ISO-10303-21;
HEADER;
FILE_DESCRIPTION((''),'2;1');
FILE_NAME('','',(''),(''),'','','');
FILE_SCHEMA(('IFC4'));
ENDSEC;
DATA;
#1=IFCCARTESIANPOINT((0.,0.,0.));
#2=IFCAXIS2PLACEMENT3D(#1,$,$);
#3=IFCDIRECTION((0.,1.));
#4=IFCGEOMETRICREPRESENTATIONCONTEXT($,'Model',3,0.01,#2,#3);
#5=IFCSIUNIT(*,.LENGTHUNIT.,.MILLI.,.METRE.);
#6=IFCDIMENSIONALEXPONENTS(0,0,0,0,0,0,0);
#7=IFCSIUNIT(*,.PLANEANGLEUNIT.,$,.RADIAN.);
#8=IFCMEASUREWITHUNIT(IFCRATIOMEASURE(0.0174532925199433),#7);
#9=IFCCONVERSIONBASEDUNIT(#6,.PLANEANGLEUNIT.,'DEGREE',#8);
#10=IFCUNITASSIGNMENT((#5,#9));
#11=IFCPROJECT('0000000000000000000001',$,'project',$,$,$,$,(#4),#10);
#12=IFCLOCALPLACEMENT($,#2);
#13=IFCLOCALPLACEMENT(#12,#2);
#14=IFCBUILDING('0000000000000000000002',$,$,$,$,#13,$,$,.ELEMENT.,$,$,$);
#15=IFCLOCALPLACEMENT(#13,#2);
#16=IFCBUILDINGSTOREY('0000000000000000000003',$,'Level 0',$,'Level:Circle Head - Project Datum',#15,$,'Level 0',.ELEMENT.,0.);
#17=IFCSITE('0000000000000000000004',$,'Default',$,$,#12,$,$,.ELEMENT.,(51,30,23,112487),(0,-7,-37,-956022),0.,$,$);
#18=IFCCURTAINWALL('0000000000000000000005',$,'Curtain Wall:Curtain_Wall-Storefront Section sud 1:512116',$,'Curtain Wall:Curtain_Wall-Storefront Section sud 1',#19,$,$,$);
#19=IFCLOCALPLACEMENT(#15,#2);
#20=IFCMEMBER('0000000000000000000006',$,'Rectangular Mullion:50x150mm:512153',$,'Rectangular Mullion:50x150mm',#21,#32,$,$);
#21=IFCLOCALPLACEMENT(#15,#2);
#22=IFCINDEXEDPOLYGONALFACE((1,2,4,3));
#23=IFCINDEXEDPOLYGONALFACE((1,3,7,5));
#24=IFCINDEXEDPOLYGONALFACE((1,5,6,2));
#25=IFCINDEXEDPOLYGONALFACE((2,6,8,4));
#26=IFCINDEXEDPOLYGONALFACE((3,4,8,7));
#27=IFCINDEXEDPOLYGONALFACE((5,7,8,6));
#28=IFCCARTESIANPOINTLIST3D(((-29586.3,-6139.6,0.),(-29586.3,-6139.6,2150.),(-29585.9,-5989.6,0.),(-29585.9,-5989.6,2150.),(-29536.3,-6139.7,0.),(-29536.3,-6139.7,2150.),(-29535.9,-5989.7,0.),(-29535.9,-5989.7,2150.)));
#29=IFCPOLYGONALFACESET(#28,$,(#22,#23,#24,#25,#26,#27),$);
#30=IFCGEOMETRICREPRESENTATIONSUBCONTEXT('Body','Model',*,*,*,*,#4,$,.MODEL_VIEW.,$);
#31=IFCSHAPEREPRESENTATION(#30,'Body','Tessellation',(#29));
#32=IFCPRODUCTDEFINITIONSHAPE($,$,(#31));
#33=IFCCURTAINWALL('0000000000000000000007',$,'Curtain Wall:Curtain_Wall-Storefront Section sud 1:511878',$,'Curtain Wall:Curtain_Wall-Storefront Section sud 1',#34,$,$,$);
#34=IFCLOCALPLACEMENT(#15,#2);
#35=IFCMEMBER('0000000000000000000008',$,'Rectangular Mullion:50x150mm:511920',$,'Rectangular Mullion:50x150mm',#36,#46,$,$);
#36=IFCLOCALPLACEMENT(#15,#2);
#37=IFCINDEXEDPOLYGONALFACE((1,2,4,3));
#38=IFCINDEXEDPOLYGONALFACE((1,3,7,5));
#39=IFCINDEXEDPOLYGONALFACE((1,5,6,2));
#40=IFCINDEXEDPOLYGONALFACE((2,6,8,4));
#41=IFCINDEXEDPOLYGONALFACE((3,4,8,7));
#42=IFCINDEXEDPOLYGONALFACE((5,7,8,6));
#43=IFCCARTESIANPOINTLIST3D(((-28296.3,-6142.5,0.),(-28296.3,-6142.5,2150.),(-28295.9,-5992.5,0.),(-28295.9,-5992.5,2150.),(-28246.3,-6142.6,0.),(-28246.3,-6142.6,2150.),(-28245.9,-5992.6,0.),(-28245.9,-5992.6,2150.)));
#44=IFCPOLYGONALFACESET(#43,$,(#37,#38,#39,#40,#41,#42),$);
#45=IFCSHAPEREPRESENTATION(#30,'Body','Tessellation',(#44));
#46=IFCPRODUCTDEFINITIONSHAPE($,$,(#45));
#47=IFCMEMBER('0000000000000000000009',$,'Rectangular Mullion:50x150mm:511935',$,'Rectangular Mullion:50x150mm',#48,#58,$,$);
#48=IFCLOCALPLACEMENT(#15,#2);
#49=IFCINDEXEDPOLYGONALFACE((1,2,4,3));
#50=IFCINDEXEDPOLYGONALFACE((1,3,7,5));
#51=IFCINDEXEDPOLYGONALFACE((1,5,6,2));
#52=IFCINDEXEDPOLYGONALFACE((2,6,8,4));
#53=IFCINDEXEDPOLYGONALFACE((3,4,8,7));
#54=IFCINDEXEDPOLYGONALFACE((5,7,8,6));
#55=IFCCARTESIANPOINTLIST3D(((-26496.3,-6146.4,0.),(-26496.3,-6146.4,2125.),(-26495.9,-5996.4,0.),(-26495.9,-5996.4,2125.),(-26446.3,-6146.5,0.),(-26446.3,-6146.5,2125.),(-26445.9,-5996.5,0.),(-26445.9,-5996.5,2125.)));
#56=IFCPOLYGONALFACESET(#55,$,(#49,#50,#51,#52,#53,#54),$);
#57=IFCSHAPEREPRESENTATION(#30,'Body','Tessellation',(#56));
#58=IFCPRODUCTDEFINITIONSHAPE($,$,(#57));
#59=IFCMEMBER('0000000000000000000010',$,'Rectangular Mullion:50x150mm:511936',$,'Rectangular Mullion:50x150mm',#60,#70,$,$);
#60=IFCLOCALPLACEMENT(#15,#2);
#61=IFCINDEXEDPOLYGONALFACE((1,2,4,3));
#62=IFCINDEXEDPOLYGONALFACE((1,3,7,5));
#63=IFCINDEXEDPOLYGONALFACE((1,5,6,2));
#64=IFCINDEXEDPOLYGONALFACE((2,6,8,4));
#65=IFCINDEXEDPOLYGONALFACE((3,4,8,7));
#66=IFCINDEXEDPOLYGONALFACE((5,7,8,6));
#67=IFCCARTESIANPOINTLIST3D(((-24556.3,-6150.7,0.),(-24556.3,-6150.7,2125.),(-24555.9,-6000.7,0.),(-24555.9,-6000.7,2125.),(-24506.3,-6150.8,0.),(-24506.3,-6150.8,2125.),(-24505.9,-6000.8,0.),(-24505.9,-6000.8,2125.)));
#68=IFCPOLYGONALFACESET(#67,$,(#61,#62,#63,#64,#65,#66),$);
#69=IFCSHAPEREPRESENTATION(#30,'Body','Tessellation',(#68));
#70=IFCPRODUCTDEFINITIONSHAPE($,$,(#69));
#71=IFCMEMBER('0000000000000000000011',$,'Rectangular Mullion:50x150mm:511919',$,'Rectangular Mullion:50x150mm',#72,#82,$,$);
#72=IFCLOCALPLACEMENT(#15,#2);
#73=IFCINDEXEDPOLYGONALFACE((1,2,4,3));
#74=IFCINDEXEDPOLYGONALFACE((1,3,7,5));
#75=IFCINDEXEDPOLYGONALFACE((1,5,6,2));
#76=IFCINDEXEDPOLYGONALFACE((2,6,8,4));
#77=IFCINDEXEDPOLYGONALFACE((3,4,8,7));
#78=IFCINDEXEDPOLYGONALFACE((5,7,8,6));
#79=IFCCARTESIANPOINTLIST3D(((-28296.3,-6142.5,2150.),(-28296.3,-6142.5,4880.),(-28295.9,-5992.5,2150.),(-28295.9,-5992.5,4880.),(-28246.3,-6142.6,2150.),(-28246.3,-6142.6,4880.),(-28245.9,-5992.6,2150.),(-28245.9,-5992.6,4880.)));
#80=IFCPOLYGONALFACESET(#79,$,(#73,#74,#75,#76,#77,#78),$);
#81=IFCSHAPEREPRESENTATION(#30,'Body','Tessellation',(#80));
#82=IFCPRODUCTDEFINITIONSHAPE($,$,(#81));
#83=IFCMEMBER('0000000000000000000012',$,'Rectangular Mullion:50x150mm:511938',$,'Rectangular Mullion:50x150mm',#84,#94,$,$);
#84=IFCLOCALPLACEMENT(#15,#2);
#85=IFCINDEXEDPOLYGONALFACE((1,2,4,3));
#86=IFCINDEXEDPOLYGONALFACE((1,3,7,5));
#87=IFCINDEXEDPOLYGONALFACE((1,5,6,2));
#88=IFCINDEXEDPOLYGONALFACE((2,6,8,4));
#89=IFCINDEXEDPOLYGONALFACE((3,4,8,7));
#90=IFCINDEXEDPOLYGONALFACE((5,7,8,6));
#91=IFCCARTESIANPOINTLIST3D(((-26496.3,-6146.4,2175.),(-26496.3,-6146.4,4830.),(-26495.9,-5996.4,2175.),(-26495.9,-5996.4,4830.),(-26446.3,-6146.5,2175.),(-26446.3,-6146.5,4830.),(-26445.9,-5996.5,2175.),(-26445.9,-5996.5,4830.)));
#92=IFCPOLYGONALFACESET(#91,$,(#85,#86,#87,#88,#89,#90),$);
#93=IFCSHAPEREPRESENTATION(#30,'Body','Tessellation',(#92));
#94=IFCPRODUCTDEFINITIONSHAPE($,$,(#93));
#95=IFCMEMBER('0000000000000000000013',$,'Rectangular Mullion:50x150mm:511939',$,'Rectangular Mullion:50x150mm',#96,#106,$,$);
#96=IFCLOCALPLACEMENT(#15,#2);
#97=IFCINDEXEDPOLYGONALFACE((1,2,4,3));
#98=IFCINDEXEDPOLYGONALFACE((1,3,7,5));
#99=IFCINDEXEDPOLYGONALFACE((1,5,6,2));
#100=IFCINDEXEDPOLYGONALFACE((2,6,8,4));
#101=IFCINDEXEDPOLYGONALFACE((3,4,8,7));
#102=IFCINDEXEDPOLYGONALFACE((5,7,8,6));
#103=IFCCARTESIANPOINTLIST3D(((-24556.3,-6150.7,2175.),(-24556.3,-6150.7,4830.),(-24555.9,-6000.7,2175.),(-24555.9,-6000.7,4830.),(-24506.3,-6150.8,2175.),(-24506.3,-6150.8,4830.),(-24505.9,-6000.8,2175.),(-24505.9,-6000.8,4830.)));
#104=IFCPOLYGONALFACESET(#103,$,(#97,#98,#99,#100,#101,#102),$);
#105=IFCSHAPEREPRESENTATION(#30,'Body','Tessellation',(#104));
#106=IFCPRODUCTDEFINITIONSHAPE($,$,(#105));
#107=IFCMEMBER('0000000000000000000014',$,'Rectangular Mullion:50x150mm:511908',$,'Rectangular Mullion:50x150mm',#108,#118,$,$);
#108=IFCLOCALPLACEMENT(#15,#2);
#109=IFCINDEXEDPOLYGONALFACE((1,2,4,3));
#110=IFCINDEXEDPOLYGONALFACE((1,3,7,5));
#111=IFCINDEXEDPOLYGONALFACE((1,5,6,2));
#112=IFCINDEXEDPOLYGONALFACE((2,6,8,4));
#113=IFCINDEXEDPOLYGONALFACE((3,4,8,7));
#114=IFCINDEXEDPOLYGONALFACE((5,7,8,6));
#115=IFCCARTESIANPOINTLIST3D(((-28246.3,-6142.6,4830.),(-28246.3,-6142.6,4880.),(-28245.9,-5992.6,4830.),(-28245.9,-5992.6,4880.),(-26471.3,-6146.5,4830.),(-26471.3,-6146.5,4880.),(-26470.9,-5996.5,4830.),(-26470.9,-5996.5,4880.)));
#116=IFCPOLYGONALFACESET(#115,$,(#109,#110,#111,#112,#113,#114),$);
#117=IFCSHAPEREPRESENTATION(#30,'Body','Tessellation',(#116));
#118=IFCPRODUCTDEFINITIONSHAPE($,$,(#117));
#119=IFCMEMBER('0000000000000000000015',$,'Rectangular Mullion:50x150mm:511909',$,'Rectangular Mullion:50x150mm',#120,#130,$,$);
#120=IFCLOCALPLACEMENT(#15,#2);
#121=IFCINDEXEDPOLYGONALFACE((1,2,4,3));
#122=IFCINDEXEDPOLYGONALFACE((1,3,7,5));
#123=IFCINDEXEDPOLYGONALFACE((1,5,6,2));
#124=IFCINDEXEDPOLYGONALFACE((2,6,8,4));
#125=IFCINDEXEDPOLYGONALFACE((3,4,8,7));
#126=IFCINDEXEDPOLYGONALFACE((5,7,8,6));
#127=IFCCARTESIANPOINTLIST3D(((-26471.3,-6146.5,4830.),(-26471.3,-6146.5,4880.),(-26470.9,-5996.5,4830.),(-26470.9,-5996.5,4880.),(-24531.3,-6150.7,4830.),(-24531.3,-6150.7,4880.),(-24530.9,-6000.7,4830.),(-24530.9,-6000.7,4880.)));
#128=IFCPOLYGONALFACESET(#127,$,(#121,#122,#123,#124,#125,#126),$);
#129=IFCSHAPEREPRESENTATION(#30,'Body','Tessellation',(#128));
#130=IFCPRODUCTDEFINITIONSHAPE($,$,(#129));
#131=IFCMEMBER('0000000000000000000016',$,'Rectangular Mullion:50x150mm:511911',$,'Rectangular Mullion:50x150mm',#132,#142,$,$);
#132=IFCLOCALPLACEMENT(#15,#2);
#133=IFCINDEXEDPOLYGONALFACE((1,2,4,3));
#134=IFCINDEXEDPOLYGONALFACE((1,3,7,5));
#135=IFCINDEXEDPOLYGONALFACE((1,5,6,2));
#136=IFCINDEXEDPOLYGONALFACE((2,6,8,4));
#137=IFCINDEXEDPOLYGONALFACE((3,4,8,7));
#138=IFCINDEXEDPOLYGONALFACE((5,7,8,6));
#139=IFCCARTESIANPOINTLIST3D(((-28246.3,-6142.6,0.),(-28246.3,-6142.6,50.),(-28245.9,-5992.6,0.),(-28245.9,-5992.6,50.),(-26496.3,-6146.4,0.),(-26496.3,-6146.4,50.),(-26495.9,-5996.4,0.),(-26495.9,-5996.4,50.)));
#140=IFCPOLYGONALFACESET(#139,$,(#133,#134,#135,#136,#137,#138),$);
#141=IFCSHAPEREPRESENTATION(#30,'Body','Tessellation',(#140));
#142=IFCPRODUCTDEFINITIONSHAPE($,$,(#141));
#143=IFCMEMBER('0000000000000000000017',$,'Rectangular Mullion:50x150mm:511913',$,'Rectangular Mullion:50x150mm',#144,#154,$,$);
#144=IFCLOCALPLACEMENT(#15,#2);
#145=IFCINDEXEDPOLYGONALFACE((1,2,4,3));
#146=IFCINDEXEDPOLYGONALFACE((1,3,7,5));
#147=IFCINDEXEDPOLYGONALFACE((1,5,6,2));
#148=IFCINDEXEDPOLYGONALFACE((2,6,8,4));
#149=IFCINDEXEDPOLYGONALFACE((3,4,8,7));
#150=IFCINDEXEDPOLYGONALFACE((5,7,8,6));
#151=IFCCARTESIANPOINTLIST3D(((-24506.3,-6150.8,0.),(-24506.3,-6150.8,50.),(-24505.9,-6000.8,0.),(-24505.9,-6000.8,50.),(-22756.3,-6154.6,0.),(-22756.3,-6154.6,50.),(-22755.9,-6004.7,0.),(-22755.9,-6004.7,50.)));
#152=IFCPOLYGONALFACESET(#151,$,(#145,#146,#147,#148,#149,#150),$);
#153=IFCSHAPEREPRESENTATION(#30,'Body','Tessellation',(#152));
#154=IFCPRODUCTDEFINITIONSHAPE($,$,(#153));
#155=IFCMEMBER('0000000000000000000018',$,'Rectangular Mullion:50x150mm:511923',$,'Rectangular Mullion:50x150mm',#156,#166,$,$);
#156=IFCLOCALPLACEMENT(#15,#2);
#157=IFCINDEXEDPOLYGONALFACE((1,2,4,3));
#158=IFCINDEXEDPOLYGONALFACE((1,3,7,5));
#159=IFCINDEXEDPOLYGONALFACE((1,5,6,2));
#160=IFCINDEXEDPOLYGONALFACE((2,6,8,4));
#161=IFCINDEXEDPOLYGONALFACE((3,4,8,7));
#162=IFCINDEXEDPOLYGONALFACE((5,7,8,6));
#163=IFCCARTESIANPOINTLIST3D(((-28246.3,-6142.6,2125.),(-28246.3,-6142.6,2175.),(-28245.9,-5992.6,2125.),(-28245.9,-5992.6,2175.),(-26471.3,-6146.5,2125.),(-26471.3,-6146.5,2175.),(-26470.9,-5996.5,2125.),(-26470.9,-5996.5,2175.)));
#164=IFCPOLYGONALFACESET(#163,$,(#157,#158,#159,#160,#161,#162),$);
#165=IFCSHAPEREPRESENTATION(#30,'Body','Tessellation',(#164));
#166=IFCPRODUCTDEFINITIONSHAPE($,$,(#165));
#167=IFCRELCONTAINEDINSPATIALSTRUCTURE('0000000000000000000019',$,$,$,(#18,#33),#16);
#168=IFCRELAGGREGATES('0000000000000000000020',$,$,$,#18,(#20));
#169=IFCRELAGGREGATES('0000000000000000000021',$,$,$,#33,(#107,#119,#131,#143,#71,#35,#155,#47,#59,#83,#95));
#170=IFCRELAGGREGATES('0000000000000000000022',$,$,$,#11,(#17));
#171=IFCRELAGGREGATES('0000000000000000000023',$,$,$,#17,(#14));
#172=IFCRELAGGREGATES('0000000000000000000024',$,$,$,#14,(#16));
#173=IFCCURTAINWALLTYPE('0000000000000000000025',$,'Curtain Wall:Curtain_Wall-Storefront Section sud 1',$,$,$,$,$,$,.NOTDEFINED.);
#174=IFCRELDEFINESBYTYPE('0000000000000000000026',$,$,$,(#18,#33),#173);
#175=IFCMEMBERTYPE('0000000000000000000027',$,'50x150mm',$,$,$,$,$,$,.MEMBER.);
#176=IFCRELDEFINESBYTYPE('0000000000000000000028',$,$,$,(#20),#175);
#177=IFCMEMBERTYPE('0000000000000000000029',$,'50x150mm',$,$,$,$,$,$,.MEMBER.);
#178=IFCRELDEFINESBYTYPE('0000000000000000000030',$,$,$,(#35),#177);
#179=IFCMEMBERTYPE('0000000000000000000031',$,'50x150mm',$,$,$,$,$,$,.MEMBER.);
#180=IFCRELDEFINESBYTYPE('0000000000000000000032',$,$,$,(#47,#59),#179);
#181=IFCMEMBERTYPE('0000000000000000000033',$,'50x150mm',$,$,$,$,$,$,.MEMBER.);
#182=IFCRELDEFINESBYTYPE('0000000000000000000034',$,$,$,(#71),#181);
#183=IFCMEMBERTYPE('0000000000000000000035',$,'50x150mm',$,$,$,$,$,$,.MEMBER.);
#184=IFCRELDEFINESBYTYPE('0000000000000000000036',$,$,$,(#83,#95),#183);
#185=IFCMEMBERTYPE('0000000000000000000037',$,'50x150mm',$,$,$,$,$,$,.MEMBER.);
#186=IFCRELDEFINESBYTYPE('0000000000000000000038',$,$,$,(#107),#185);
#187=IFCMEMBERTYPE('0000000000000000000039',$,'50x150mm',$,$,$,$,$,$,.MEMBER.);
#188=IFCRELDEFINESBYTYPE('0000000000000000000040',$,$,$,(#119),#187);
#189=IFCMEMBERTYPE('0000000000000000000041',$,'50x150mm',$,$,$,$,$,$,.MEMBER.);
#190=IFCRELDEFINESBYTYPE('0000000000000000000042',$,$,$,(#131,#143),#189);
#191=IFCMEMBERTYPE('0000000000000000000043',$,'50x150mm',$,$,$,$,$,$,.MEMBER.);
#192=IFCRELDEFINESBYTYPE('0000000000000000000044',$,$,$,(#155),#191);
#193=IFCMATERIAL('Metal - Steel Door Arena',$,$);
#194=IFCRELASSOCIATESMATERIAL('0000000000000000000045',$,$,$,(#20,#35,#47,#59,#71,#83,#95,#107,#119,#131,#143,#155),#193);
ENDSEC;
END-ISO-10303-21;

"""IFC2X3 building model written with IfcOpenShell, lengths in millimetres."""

from ifc_helpers import new_model, entity, si_unit, converted_unit, direction, frame, origin, origin_2d_with_axis, place, context, subcontext, project, spatial, rectangle, extrude, source, transform, mapped, material, type_object, type_shapes, element, aggregate, save


model = new_model("IFC2X3")

# Units and contexts
model_context = context("Model", 3, precision=0.01, world=origin(), true_north=direction((0.0, 1.0)))
body_context = subcontext(model_context, "Body", "Model", "MODEL_VIEW")
ifc_project = project(units=[si_unit("LENGTHUNIT", "METRE", prefix="MILLI"), converted_unit("PLANEANGLEUNIT", "DEGREE", entity("IfcRatioMeasure", 0.0174532925199433), si_unit("PLANEANGLEUNIT", "RADIAN"), dimensions=[0, 0, 0, 0, 0, 0, 0])], contexts=[model_context])

# Site, building, storey
site_placement = place(None, origin())
site = spatial("IfcSite", under=ifc_project, at=site_placement, Name="Default", CompositionType="ELEMENT", RefLatitude=(51, 30, 23, 112487), RefLongitude=(0, -7, -37, -956022), RefElevation=0.0)
building_placement = place(site_placement, origin())
building = spatial("IfcBuilding", under=site, at=building_placement, CompositionType="ELEMENT")
storey_placement = place(building_placement, origin())
storey = spatial("IfcBuildingStorey", under=building, at=storey_placement, Name="Level 0", ObjectType="Level:Circle Head - Project Datum", LongName="Level 0", CompositionType="ELEMENT", Elevation=0.0)

# Curtain wall, member
curtain_wall_type = type_object("IfcCurtainWallType", Name="Curtain Wall:Curtain_Wall-Storefront Section sud 1", PredefinedType="NOTDEFINED")
curtain_wall_1_placement = place(storey_placement, origin())
curtain_wall_1 = element("IfcCurtainWall", 1, at=curtain_wall_1_placement, inside=storey, type_object=curtain_wall_type, Name="Curtain Wall:Curtain_Wall-Storefront Section sud 1:512116", ObjectType="Curtain Wall:Curtain_Wall-Storefront Section sud 1")
ifc_material_1 = material(Name="Metal - Steel Door Arena")
member_type_1 = type_object("IfcMemberType", Name="50x150mm", PredefinedType="MEMBER")
shared_shape_1 = source(origin(), body_context, "Body", "SweptSolid", [
    extrude(rectangle(XDim=150.0, YDim=50.0, at=origin_2d_with_axis()), frame((-25.0, 0.0, -2150.0), z_axis=(0.0, 0.0, 1.0), x_axis=(0.0, -1.0, 0.0)), (0.0, 0.0, 1.0), 2150.0),
])
type_shapes(member_type_1, [shared_shape_1])
member_1_placement = place(storey_placement, frame((-29536.1, -6064.7, 0.0), z_axis=(0.0, 0.0, -1.0), x_axis=(0.999998, -0.002199, 0.0)))
member_1 = element("IfcMember", 2, at=member_1_placement, type_object=member_type_1, material=ifc_material_1, Name="Rectangular Mullion:50x150mm:512153", ObjectType="Rectangular Mullion:50x150mm", context=body_context, shape_type="MappedRepresentation", body=[
    mapped(shared_shape_1, transform((0.0, 0.0, 0.0), scale=1.0)),
])
aggregate(curtain_wall_1, [member_1])

# Curtain wall, members
curtain_wall_2_placement = place(storey_placement, origin())
curtain_wall_2 = element("IfcCurtainWall", 3, at=curtain_wall_2_placement, inside=storey, type_object=curtain_wall_type, Name="Curtain Wall:Curtain_Wall-Storefront Section sud 1:511878", ObjectType="Curtain Wall:Curtain_Wall-Storefront Section sud 1")
member_type_2 = type_object("IfcMemberType", Name="50x150mm", PredefinedType="MEMBER")
shared_shape_2 = source(origin(), body_context, "Body", "SweptSolid", [
    extrude(rectangle(XDim=150.0, YDim=50.0, at=origin_2d_with_axis()), frame((-25.0, 0.0, -2150.0), z_axis=(0.0, 0.0, 1.0), x_axis=(0.0, -1.0, 0.0)), (0.0, 0.0, 1.0), 2150.0),
])
type_shapes(member_type_2, [shared_shape_2])
member_2_placement = place(storey_placement, frame((-28296.1, -6067.5, 2150.0), z_axis=(0.0, 0.0, 1.0), x_axis=(-0.999998, 0.002199, 0.0)))
member_2 = element("IfcMember", 4, at=member_2_placement, type_object=member_type_2, material=ifc_material_1, Name="Rectangular Mullion:50x150mm:511920", ObjectType="Rectangular Mullion:50x150mm", context=body_context, shape_type="MappedRepresentation", body=[
    mapped(shared_shape_2, transform((0.0, 0.0, 0.0), scale=1.0)),
])
member_type_3 = type_object("IfcMemberType", Name="50x150mm", PredefinedType="MEMBER")
shared_shape_3 = source(origin(), body_context, "Body", "SweptSolid", [
    extrude(rectangle(XDim=150.0, YDim=50.0, at=origin_2d_with_axis()), frame((0.0, 0.0, -2125.0), z_axis=(0.0, 0.0, 1.0), x_axis=(0.0, -1.0, 0.0)), (0.0, 0.0, 1.0), 2125.0),
])
type_shapes(member_type_3, [shared_shape_3])
member_3_placement = place(storey_placement, frame((-26471.1, -6071.5, 0.0), z_axis=(0.0, 0.0, -1.0), x_axis=(0.999998, -0.002199, 0.0)))
member_3 = element("IfcMember", 5, at=member_3_placement, type_object=member_type_3, material=ifc_material_1, Name="Rectangular Mullion:50x150mm:511935", ObjectType="Rectangular Mullion:50x150mm", context=body_context, shape_type="MappedRepresentation", body=[
    mapped(shared_shape_3, transform((0.0, 0.0, 0.0), scale=1.0)),
])
member_4_placement = place(storey_placement, frame((-24531.1, -6075.7, 0.0), z_axis=(0.0, 0.0, -1.0), x_axis=(0.999998, -0.002199, 0.0)))
member_4 = element("IfcMember", 6, at=member_4_placement, type_object=member_type_3, material=ifc_material_1, Name="Rectangular Mullion:50x150mm:511936", ObjectType="Rectangular Mullion:50x150mm", context=body_context, shape_type="MappedRepresentation", body=[
    mapped(shared_shape_3, transform((0.0, 0.0, 0.0), scale=1.0)),
])
member_type_4 = type_object("IfcMemberType", Name="50x150mm", PredefinedType="MEMBER")
shared_shape_4 = source(origin(), body_context, "Body", "SweptSolid", [
    extrude(rectangle(XDim=150.0, YDim=50.0, at=origin_2d_with_axis()), frame((-25.0, 0.0, -2730.0), z_axis=(0.0, 0.0, 1.0), x_axis=(0.0, -1.0, 0.0)), (0.0, 0.0, 1.0), 2730.0),
])
type_shapes(member_type_4, [shared_shape_4])
member_5_placement = place(storey_placement, frame((-28296.1, -6067.5, 4880.0), z_axis=(0.0, 0.0, 1.0), x_axis=(-0.999998, 0.002199, 0.0)))
member_5 = element("IfcMember", 7, at=member_5_placement, type_object=member_type_4, material=ifc_material_1, Name="Rectangular Mullion:50x150mm:511919", ObjectType="Rectangular Mullion:50x150mm", context=body_context, shape_type="MappedRepresentation", body=[
    mapped(shared_shape_4, transform((0.0, 0.0, 0.0), scale=1.0)),
])
member_type_5 = type_object("IfcMemberType", Name="50x150mm", PredefinedType="MEMBER")
shared_shape_5 = source(origin(), body_context, "Body", "SweptSolid", [
    extrude(rectangle(XDim=150.0, YDim=50.0, at=origin_2d_with_axis()), frame((0.0, 0.0, -2655.0), z_axis=(0.0, 0.0, 1.0), x_axis=(0.0, -1.0, 0.0)), (0.0, 0.0, 1.0), 2655.0),
])
type_shapes(member_type_5, [shared_shape_5])
member_6_placement = place(storey_placement, frame((-26471.1, -6071.5, 2175.0), z_axis=(0.0, 0.0, -1.0), x_axis=(0.999998, -0.002199, 0.0)))
member_6 = element("IfcMember", 8, at=member_6_placement, type_object=member_type_5, material=ifc_material_1, Name="Rectangular Mullion:50x150mm:511938", ObjectType="Rectangular Mullion:50x150mm", context=body_context, shape_type="MappedRepresentation", body=[
    mapped(shared_shape_5, transform((0.0, 0.0, 0.0), scale=1.0)),
])
member_7_placement = place(storey_placement, frame((-24531.1, -6075.7, 2175.0), z_axis=(0.0, 0.0, -1.0), x_axis=(0.999998, -0.002199, 0.0)))
member_7 = element("IfcMember", 9, at=member_7_placement, type_object=member_type_5, material=ifc_material_1, Name="Rectangular Mullion:50x150mm:511939", ObjectType="Rectangular Mullion:50x150mm", context=body_context, shape_type="MappedRepresentation", body=[
    mapped(shared_shape_5, transform((0.0, 0.0, 0.0), scale=1.0)),
])
member_type_6 = type_object("IfcMemberType", Name="50x150mm", PredefinedType="MEMBER")
shared_shape_6 = source(origin(), body_context, "Body", "SweptSolid", [
    extrude(rectangle(XDim=150.0, YDim=50.0, at=origin_2d_with_axis()), frame((-25.0, 0.0, -1775.0), z_axis=(0.0, 0.0, 1.0), x_axis=(0.0, -1.0, 0.0)), (0.0, 0.0, 1.0), 1775.0),
])
type_shapes(member_type_6, [shared_shape_6])
member_8_placement = place(storey_placement, frame((-26471.1, -6071.5, 4880.0), z_axis=(0.999998, -0.002199, 0.0), x_axis=(0.0, 0.0, 1.0)))
member_8 = element("IfcMember", 10, at=member_8_placement, type_object=member_type_6, material=ifc_material_1, Name="Rectangular Mullion:50x150mm:511908", ObjectType="Rectangular Mullion:50x150mm", context=body_context, shape_type="MappedRepresentation", body=[
    mapped(shared_shape_6, transform((0.0, 0.0, 0.0), scale=1.0)),
])
member_type_7 = type_object("IfcMemberType", Name="50x150mm", PredefinedType="MEMBER")
shared_shape_7 = source(origin(), body_context, "Body", "SweptSolid", [
    extrude(rectangle(XDim=150.0, YDim=50.0, at=origin_2d_with_axis()), frame((-25.0, 0.0, -1940.0), z_axis=(0.0, 0.0, 1.0), x_axis=(0.0, -1.0, 0.0)), (0.0, 0.0, 1.0), 1940.0),
])
type_shapes(member_type_7, [shared_shape_7])
member_9_placement = place(storey_placement, frame((-24531.1, -6075.7, 4880.0), z_axis=(0.999998, -0.002199, 0.0), x_axis=(0.0, 0.0, 1.0)))
member_9 = element("IfcMember", 11, at=member_9_placement, type_object=member_type_7, material=ifc_material_1, Name="Rectangular Mullion:50x150mm:511909", ObjectType="Rectangular Mullion:50x150mm", context=body_context, shape_type="MappedRepresentation", body=[
    mapped(shared_shape_7, transform((0.0, 0.0, 0.0), scale=1.0)),
])
member_type_8 = type_object("IfcMemberType", Name="50x150mm", PredefinedType="MEMBER")
shared_shape_8 = source(origin(), body_context, "Body", "SweptSolid", [
    extrude(rectangle(XDim=150.0, YDim=50.0, at=origin_2d_with_axis()), frame((-25.0, 0.0, -1750.0), z_axis=(0.0, 0.0, 1.0), x_axis=(0.0, -1.0, 0.0)), (0.0, 0.0, 1.0), 1750.0),
])
type_shapes(member_type_8, [shared_shape_8])
member_10_placement = place(storey_placement, frame((-28246.1, -6067.6, 0.0), z_axis=(-0.999998, 0.002199, 0.0), x_axis=(0.0, 0.0, -1.0)))
member_10 = element("IfcMember", 12, at=member_10_placement, type_object=member_type_8, material=ifc_material_1, Name="Rectangular Mullion:50x150mm:511911", ObjectType="Rectangular Mullion:50x150mm", context=body_context, shape_type="MappedRepresentation", body=[
    mapped(shared_shape_8, transform((0.0, 0.0, 0.0), scale=1.0)),
])
member_11_placement = place(storey_placement, frame((-24506.1, -6075.8, 0.0), z_axis=(-0.999998, 0.002199, 0.0), x_axis=(0.0, 0.0, -1.0)))
member_11 = element("IfcMember", 13, at=member_11_placement, type_object=member_type_8, material=ifc_material_1, Name="Rectangular Mullion:50x150mm:511913", ObjectType="Rectangular Mullion:50x150mm", context=body_context, shape_type="MappedRepresentation", body=[
    mapped(shared_shape_8, transform((0.0, 0.0, 0.0), scale=1.0)),
])
member_type_9 = type_object("IfcMemberType", Name="50x150mm", PredefinedType="MEMBER")
shared_shape_9 = source(origin(), body_context, "Body", "SweptSolid", [
    extrude(rectangle(XDim=150.0, YDim=50.0, at=origin_2d_with_axis()), frame((0.0, 0.0, -1775.0), z_axis=(0.0, 0.0, 1.0), x_axis=(0.0, -1.0, 0.0)), (0.0, 0.0, 1.0), 1775.0),
])
type_shapes(member_type_9, [shared_shape_9])
member_12_placement = place(storey_placement, frame((-26471.1, -6071.5, 2150.0), z_axis=(0.999998, -0.002199, 0.0), x_axis=(0.0, 0.0, 1.0)))
member_12 = element("IfcMember", 14, at=member_12_placement, type_object=member_type_9, material=ifc_material_1, Name="Rectangular Mullion:50x150mm:511923", ObjectType="Rectangular Mullion:50x150mm", context=body_context, shape_type="MappedRepresentation", body=[
    mapped(shared_shape_9, transform((0.0, 0.0, 0.0), scale=1.0)),
])
aggregate(curtain_wall_2, [member_8, member_9, member_10, member_11, member_5, member_2, member_12, member_3, member_4, member_6, member_7])

save(model, "model.ifc")
